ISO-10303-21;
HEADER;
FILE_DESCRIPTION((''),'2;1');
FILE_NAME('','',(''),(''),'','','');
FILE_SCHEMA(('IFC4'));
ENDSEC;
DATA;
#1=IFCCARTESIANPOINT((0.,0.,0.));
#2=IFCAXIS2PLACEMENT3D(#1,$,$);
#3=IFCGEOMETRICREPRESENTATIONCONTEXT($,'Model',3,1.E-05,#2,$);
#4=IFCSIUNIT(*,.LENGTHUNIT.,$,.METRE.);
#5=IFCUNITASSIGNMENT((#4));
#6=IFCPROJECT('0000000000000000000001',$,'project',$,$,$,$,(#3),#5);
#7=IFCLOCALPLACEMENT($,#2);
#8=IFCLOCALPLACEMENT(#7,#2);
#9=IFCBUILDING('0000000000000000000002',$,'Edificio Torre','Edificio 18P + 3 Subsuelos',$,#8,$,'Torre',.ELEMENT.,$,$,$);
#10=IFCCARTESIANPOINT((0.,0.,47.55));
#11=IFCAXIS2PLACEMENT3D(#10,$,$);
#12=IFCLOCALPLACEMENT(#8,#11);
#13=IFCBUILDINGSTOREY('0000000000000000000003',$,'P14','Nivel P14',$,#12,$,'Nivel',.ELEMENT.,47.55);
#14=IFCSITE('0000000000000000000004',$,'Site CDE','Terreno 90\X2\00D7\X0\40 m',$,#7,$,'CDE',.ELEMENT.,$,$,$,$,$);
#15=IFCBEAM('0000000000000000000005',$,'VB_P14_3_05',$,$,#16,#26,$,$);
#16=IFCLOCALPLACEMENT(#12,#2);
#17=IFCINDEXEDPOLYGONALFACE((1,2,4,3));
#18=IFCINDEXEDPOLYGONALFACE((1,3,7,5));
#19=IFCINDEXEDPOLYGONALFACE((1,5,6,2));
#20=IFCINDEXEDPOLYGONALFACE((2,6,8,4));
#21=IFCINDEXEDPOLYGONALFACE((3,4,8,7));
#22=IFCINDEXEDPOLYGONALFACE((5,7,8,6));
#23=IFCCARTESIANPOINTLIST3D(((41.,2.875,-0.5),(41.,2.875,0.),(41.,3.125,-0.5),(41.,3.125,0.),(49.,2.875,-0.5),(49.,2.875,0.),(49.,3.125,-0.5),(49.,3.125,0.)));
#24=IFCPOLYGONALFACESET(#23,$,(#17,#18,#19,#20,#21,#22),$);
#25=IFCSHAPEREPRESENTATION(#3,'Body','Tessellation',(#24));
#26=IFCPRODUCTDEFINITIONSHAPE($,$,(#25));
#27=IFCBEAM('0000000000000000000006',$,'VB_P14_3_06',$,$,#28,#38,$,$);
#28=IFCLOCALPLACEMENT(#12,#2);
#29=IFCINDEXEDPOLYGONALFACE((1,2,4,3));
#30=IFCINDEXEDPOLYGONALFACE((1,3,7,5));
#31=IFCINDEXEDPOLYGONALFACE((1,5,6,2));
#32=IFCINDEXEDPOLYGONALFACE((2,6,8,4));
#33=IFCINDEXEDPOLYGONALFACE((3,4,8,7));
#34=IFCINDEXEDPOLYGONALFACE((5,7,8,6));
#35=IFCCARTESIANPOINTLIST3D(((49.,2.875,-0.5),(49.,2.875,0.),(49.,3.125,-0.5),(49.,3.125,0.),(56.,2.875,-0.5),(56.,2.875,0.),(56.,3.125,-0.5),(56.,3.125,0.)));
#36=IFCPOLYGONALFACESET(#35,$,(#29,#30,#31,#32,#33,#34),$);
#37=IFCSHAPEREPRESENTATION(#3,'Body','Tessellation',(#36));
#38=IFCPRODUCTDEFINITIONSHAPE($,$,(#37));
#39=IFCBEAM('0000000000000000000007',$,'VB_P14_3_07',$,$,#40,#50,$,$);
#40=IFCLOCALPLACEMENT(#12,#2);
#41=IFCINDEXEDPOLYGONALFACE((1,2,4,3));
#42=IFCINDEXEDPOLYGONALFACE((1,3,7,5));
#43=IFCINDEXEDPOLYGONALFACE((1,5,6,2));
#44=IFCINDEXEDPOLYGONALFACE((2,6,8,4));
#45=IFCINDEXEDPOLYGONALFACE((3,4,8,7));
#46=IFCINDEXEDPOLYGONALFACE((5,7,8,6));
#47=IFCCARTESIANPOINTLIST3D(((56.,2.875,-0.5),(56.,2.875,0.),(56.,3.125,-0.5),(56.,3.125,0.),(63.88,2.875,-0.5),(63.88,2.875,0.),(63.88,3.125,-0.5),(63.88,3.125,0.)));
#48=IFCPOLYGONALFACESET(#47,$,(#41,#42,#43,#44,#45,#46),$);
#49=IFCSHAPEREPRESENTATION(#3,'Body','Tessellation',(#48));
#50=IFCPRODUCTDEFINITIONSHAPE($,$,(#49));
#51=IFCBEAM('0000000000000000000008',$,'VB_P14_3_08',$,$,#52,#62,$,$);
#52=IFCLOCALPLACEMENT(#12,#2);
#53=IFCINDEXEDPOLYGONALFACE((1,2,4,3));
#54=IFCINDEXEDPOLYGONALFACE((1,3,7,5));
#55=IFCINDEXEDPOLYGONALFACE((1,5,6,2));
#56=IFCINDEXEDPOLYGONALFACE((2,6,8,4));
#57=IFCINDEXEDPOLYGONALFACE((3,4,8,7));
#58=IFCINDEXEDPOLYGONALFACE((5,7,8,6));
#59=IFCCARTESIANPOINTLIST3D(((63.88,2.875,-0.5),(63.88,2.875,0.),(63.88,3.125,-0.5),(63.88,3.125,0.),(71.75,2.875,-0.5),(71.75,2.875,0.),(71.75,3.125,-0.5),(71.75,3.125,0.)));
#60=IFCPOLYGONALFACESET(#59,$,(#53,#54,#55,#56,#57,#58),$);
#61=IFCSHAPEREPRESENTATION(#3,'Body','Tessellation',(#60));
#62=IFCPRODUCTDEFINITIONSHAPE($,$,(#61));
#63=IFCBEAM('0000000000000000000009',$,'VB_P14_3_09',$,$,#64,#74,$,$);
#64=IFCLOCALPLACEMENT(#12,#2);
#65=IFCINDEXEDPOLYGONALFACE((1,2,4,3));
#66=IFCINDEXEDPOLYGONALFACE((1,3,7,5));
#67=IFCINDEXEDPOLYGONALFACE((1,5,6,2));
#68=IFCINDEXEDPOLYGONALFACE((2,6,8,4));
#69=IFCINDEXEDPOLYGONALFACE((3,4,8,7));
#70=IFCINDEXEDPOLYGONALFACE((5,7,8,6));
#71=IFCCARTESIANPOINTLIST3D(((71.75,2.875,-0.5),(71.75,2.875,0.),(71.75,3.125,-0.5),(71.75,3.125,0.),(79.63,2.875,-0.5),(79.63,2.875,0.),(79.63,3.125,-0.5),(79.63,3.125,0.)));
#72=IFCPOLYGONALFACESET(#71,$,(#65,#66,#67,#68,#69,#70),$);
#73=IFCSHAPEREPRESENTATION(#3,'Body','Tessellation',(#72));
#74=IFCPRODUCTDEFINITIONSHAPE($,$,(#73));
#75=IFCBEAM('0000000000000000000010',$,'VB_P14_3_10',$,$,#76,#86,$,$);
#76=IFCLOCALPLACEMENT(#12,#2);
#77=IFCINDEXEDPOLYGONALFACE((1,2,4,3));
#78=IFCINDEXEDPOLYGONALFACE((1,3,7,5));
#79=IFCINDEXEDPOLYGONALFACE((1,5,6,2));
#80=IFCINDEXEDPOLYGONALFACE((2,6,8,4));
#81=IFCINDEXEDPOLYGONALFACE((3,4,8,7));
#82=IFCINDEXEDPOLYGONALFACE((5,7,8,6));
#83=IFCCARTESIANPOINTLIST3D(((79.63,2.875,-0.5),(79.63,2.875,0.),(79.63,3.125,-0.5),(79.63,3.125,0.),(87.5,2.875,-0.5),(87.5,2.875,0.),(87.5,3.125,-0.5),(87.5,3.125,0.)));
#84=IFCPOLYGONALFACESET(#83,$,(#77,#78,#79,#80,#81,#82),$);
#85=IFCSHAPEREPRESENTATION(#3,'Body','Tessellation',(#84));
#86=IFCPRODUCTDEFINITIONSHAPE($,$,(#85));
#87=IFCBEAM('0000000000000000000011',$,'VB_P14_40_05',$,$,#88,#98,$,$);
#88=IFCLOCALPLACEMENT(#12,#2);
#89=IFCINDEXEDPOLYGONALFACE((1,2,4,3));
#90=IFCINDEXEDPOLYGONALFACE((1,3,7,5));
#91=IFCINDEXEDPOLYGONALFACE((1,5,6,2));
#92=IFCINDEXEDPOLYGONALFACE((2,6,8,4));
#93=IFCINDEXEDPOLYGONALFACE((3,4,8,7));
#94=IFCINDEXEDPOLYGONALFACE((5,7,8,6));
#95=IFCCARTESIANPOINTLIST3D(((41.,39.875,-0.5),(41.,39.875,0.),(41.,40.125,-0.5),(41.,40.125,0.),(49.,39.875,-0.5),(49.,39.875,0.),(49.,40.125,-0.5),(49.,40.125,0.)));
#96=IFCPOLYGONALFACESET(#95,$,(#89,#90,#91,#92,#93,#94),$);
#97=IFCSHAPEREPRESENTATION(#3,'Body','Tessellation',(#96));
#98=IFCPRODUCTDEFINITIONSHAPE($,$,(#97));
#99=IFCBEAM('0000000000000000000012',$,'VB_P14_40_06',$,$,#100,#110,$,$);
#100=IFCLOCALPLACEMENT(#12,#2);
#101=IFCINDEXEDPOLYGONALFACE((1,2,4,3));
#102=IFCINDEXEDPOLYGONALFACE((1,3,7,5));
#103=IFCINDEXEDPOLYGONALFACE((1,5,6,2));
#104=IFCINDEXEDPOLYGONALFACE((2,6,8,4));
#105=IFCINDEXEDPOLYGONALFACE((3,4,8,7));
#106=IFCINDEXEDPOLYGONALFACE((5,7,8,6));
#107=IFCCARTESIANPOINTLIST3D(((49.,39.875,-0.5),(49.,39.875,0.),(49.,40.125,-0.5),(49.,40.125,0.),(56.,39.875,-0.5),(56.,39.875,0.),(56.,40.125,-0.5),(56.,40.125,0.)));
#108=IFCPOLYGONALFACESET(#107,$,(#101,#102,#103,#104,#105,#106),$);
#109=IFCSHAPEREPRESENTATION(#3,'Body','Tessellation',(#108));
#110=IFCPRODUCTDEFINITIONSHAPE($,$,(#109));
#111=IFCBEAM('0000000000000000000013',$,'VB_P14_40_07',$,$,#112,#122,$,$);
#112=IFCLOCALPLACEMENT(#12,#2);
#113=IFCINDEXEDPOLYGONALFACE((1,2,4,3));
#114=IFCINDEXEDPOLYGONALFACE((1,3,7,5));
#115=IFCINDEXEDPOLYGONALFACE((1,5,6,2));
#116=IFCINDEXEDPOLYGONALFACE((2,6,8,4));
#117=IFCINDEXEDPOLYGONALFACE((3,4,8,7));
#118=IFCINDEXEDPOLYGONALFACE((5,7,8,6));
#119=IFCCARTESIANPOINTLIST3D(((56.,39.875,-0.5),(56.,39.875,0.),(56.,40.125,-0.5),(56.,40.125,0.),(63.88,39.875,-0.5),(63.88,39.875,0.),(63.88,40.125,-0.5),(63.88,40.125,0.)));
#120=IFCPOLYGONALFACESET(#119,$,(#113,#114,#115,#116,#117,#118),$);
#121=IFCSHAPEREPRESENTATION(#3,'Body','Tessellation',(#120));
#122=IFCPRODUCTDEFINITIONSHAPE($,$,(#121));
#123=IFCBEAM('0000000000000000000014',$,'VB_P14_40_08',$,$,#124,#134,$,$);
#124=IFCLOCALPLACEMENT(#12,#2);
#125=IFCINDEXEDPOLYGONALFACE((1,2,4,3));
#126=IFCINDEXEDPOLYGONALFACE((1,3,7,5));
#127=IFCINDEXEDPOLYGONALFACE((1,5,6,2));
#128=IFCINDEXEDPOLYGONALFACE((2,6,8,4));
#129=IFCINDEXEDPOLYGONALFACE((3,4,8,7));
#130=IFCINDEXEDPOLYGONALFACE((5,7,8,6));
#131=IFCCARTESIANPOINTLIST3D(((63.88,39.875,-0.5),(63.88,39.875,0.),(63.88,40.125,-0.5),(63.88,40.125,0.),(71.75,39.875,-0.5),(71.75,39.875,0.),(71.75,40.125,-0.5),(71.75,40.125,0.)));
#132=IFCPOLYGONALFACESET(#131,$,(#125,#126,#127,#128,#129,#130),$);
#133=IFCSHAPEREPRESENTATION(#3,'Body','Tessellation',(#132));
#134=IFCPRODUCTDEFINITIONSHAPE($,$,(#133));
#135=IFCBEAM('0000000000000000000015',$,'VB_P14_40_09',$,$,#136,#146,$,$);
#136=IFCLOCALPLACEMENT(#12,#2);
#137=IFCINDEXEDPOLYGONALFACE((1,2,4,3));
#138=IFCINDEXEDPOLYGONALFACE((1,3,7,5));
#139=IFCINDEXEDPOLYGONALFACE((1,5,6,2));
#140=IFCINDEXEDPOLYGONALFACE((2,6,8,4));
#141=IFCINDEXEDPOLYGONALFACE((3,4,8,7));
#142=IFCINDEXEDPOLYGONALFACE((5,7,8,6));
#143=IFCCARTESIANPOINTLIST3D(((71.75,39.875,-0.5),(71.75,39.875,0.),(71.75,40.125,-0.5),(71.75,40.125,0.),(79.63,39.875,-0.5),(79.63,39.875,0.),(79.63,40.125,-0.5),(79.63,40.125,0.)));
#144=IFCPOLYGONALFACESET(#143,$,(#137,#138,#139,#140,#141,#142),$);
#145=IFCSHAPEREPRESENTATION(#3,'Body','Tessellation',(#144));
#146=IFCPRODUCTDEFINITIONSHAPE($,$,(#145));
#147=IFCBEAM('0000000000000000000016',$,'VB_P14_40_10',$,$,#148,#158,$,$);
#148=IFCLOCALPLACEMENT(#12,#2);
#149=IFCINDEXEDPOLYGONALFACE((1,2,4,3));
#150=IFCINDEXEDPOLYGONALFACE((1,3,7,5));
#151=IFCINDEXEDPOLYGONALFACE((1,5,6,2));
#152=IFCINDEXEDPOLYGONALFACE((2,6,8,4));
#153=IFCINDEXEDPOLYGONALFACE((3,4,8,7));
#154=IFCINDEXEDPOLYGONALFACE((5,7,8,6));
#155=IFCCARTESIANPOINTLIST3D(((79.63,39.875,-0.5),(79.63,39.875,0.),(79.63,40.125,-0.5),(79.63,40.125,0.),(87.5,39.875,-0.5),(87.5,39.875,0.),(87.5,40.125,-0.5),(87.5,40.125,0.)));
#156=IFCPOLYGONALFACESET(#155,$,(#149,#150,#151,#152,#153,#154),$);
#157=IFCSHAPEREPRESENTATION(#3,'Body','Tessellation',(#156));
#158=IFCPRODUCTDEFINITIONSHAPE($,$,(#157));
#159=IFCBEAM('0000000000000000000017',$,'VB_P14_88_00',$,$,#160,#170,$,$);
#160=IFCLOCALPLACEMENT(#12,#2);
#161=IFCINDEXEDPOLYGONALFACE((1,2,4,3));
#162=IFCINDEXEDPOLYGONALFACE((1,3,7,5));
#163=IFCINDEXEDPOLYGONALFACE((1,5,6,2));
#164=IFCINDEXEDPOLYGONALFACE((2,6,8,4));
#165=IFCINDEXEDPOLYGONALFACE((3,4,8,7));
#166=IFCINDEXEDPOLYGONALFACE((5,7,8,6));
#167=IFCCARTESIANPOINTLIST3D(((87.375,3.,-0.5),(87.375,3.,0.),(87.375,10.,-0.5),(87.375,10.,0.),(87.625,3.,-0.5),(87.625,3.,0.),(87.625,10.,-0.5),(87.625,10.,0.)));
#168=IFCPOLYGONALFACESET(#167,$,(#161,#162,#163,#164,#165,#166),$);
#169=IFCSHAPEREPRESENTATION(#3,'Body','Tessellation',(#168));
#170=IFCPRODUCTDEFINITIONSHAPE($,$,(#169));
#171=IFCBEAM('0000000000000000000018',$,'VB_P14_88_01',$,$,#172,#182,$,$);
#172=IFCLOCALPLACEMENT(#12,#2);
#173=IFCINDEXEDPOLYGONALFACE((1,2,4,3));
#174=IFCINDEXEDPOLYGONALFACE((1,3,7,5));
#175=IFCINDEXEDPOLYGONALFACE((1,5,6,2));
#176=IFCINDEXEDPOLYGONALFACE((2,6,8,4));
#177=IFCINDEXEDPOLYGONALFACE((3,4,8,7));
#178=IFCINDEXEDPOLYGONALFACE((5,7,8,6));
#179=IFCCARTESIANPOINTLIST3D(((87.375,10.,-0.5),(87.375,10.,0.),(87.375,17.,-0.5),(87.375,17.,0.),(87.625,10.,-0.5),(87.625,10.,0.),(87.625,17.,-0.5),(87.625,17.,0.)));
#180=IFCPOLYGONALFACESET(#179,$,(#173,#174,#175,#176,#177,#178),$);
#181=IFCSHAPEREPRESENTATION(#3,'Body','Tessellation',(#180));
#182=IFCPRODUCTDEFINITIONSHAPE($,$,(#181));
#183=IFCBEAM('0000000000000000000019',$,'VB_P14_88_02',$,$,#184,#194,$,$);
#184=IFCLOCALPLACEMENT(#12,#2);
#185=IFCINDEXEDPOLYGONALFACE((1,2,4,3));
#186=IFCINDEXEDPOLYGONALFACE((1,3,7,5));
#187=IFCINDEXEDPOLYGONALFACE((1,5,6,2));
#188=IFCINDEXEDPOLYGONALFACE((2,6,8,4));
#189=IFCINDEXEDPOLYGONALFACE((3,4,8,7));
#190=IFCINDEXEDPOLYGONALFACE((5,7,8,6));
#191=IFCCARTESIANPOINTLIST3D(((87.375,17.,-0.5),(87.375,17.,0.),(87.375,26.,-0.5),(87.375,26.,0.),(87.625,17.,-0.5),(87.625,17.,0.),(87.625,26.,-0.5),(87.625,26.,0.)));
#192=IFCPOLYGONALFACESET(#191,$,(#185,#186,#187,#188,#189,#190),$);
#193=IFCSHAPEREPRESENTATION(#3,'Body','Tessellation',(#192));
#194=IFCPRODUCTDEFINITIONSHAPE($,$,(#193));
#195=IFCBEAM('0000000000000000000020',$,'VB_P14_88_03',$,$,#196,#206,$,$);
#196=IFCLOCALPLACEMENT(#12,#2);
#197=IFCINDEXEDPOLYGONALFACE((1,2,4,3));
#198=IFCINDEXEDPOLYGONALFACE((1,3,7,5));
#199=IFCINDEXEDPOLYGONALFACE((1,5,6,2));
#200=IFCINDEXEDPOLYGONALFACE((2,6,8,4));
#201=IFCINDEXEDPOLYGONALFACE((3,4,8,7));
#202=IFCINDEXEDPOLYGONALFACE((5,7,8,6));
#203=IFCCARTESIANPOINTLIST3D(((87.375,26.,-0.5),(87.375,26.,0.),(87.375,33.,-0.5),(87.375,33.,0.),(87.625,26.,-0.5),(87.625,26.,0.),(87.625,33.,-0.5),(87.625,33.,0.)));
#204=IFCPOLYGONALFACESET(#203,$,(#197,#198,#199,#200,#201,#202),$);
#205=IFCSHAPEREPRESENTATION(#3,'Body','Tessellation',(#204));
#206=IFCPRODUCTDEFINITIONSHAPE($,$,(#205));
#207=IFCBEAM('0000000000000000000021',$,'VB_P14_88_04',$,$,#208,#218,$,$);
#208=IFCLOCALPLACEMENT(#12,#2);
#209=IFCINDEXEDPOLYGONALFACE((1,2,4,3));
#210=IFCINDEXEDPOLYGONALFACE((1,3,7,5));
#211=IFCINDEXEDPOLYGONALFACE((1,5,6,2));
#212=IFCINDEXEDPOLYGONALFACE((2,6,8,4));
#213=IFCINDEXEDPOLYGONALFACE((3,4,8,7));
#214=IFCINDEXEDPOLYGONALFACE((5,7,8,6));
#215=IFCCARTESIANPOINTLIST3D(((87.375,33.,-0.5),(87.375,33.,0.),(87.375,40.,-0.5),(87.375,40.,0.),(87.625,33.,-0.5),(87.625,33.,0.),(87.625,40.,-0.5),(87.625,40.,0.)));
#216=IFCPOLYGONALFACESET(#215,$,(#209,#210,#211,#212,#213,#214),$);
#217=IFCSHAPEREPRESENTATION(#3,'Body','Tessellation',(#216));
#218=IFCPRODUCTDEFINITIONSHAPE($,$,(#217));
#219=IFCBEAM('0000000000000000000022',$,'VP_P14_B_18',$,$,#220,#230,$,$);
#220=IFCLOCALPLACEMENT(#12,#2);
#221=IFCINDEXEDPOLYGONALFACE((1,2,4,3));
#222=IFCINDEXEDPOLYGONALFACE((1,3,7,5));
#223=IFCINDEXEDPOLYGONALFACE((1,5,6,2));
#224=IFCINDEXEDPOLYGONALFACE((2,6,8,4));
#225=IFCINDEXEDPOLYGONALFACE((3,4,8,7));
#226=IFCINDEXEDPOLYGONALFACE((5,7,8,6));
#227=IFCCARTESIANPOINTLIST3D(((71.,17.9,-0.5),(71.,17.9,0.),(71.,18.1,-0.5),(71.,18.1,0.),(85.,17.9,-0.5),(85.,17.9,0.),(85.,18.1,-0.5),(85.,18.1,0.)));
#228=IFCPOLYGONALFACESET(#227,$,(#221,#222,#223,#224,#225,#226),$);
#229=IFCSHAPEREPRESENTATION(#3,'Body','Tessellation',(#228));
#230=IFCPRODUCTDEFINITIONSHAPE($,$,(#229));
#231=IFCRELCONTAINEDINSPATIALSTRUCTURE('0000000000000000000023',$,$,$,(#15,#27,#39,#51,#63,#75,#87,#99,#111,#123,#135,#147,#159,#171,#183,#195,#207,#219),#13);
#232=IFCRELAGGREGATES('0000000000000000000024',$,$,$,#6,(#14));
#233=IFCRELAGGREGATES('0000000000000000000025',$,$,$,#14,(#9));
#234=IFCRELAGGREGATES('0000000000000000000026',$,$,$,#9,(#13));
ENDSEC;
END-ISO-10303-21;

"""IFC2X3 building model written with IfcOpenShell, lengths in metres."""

from ifc_helpers import new_model, si_unit, frame, origin, origin_2d, place, context, project, spatial, rectangle, extrude, element, save


model = new_model("IFC2X3")

# Units and contexts
model_context = context("Model", 3, precision=1e-05, world=origin())
ifc_project = project(units=[si_unit("LENGTHUNIT", "METRE")], contexts=[model_context])

# Site, building, storey
site_placement = place(None, origin())
site = spatial("IfcSite", under=ifc_project, at=site_placement, Name="Site CDE", Description="Terreno 90×40 m", LongName="CDE", CompositionType="ELEMENT")
building_placement = place(site_placement, origin())
building = spatial("IfcBuilding", under=site, at=building_placement, Name="Edificio Torre", Description="Edificio 18P + 3 Subsuelos", LongName="Torre", CompositionType="ELEMENT")
storey_placement = place(building_placement, frame((0.0, 0.0, 47.55)))
storey = spatial("IfcBuildingStorey", under=building, at=storey_placement, Name="P14", Description="Nivel P14", LongName="Nivel", CompositionType="ELEMENT", Elevation=47.55)

# Beams
beam_1_placement = place(storey_placement, frame((45.0, 3.0, -0.5)))
element("IfcBeam", 1, at=beam_1_placement, inside=storey, Name="VB_P14_3_05", context=model_context, shape_type="SweptSolid", body=[
    extrude(rectangle(XDim=8.0, YDim=0.25, at=origin_2d()), origin(), (0.0, 0.0, 1.0), 0.5),
])
beam_2_placement = place(storey_placement, frame((52.5, 3.0, -0.5)))
element("IfcBeam", 2, at=beam_2_placement, inside=storey, Name="VB_P14_3_06", context=model_context, shape_type="SweptSolid", body=[
    extrude(rectangle(XDim=7.0, YDim=0.25, at=origin_2d()), origin(), (0.0, 0.0, 1.0), 0.5),
])
beam_3_placement = place(storey_placement, frame((59.94, 3.0, -0.5)))
element("IfcBeam", 3, at=beam_3_placement, inside=storey, Name="VB_P14_3_07", context=model_context, shape_type="SweptSolid", body=[
    extrude(rectangle(XDim=7.88, YDim=0.25, at=origin_2d()), origin(), (0.0, 0.0, 1.0), 0.5),
])
beam_4_placement = place(storey_placement, frame((67.815, 3.0, -0.5)))
element("IfcBeam", 4, at=beam_4_placement, inside=storey, Name="VB_P14_3_08", context=model_context, shape_type="SweptSolid", body=[
    extrude(rectangle(XDim=7.87, YDim=0.25, at=origin_2d()), origin(), (0.0, 0.0, 1.0), 0.5),
])
beam_5_placement = place(storey_placement, frame((75.69, 3.0, -0.5)))
element("IfcBeam", 5, at=beam_5_placement, inside=storey, Name="VB_P14_3_09", context=model_context, shape_type="SweptSolid", body=[
    extrude(rectangle(XDim=7.88, YDim=0.25, at=origin_2d()), origin(), (0.0, 0.0, 1.0), 0.5),
])
beam_6_placement = place(storey_placement, frame((83.565, 3.0, -0.5)))
element("IfcBeam", 6, at=beam_6_placement, inside=storey, Name="VB_P14_3_10", context=model_context, shape_type="SweptSolid", body=[
    extrude(rectangle(XDim=7.87, YDim=0.25, at=origin_2d()), origin(), (0.0, 0.0, 1.0), 0.5),
])
beam_7_placement = place(storey_placement, frame((45.0, 40.0, -0.5)))
element("IfcBeam", 7, at=beam_7_placement, inside=storey, Name="VB_P14_40_05", context=model_context, shape_type="SweptSolid", body=[
    extrude(rectangle(XDim=8.0, YDim=0.25, at=origin_2d()), origin(), (0.0, 0.0, 1.0), 0.5),
])
beam_8_placement = place(storey_placement, frame((52.5, 40.0, -0.5)))
element("IfcBeam", 8, at=beam_8_placement, inside=storey, Name="VB_P14_40_06", context=model_context, shape_type="SweptSolid", body=[
    extrude(rectangle(XDim=7.0, YDim=0.25, at=origin_2d()), origin(), (0.0, 0.0, 1.0), 0.5),
])
beam_9_placement = place(storey_placement, frame((59.94, 40.0, -0.5)))
element("IfcBeam", 9, at=beam_9_placement, inside=storey, Name="VB_P14_40_07", context=model_context, shape_type="SweptSolid", body=[
    extrude(rectangle(XDim=7.88, YDim=0.25, at=origin_2d()), origin(), (0.0, 0.0, 1.0), 0.5),
])
beam_10_placement = place(storey_placement, frame((67.815, 40.0, -0.5)))
element("IfcBeam", 10, at=beam_10_placement, inside=storey, Name="VB_P14_40_08", context=model_context, shape_type="SweptSolid", body=[
    extrude(rectangle(XDim=7.87, YDim=0.25, at=origin_2d()), origin(), (0.0, 0.0, 1.0), 0.5),
])
beam_11_placement = place(storey_placement, frame((75.69, 40.0, -0.5)))
element("IfcBeam", 11, at=beam_11_placement, inside=storey, Name="VB_P14_40_09", context=model_context, shape_type="SweptSolid", body=[
    extrude(rectangle(XDim=7.88, YDim=0.25, at=origin_2d()), origin(), (0.0, 0.0, 1.0), 0.5),
])
beam_12_placement = place(storey_placement, frame((83.565, 40.0, -0.5)))
element("IfcBeam", 12, at=beam_12_placement, inside=storey, Name="VB_P14_40_10", context=model_context, shape_type="SweptSolid", body=[
    extrude(rectangle(XDim=7.87, YDim=0.25, at=origin_2d()), origin(), (0.0, 0.0, 1.0), 0.5),
])
for number, where, name in (
    (13, (87.5, 6.5, -0.5), "VB_P14_88_00"),
    (14, (87.5, 13.5, -0.5), "VB_P14_88_01"),
):
    element("IfcBeam", number, at=place(storey_placement, frame(where)), inside=storey, Name=name, context=model_context, shape_type="SweptSolid", body=[
        extrude(rectangle(XDim=0.25, YDim=7.0, at=origin_2d()), origin(), (0.0, 0.0, 1.0), 0.5),
    ])
beam_13_placement = place(storey_placement, frame((87.5, 21.5, -0.5)))
element("IfcBeam", 15, at=beam_13_placement, inside=storey, Name="VB_P14_88_02", context=model_context, shape_type="SweptSolid", body=[
    extrude(rectangle(XDim=0.25, YDim=9.0, at=origin_2d()), origin(), (0.0, 0.0, 1.0), 0.5),
])
for number, where, name in (
    (16, (87.5, 29.5, -0.5), "VB_P14_88_03"),
    (17, (87.5, 36.5, -0.5), "VB_P14_88_04"),
):
    element("IfcBeam", number, at=place(storey_placement, frame(where)), inside=storey, Name=name, context=model_context, shape_type="SweptSolid", body=[
        extrude(rectangle(XDim=0.25, YDim=7.0, at=origin_2d()), origin(), (0.0, 0.0, 1.0), 0.5),
    ])
for number, where, name in (
    (18, (78.0, 18.0, -0.5), "VP_P14_B_18"),
):
    element("IfcBeam", number, at=place(storey_placement, frame(where)), inside=storey, Name=name, context=model_context, shape_type="SweptSolid", body=[
        extrude(rectangle(XDim=14.0, YDim=0.2, at=origin_2d()), origin(), (0.0, 0.0, 1.0), 0.5),
    ])

save(model, "model.ifc")
